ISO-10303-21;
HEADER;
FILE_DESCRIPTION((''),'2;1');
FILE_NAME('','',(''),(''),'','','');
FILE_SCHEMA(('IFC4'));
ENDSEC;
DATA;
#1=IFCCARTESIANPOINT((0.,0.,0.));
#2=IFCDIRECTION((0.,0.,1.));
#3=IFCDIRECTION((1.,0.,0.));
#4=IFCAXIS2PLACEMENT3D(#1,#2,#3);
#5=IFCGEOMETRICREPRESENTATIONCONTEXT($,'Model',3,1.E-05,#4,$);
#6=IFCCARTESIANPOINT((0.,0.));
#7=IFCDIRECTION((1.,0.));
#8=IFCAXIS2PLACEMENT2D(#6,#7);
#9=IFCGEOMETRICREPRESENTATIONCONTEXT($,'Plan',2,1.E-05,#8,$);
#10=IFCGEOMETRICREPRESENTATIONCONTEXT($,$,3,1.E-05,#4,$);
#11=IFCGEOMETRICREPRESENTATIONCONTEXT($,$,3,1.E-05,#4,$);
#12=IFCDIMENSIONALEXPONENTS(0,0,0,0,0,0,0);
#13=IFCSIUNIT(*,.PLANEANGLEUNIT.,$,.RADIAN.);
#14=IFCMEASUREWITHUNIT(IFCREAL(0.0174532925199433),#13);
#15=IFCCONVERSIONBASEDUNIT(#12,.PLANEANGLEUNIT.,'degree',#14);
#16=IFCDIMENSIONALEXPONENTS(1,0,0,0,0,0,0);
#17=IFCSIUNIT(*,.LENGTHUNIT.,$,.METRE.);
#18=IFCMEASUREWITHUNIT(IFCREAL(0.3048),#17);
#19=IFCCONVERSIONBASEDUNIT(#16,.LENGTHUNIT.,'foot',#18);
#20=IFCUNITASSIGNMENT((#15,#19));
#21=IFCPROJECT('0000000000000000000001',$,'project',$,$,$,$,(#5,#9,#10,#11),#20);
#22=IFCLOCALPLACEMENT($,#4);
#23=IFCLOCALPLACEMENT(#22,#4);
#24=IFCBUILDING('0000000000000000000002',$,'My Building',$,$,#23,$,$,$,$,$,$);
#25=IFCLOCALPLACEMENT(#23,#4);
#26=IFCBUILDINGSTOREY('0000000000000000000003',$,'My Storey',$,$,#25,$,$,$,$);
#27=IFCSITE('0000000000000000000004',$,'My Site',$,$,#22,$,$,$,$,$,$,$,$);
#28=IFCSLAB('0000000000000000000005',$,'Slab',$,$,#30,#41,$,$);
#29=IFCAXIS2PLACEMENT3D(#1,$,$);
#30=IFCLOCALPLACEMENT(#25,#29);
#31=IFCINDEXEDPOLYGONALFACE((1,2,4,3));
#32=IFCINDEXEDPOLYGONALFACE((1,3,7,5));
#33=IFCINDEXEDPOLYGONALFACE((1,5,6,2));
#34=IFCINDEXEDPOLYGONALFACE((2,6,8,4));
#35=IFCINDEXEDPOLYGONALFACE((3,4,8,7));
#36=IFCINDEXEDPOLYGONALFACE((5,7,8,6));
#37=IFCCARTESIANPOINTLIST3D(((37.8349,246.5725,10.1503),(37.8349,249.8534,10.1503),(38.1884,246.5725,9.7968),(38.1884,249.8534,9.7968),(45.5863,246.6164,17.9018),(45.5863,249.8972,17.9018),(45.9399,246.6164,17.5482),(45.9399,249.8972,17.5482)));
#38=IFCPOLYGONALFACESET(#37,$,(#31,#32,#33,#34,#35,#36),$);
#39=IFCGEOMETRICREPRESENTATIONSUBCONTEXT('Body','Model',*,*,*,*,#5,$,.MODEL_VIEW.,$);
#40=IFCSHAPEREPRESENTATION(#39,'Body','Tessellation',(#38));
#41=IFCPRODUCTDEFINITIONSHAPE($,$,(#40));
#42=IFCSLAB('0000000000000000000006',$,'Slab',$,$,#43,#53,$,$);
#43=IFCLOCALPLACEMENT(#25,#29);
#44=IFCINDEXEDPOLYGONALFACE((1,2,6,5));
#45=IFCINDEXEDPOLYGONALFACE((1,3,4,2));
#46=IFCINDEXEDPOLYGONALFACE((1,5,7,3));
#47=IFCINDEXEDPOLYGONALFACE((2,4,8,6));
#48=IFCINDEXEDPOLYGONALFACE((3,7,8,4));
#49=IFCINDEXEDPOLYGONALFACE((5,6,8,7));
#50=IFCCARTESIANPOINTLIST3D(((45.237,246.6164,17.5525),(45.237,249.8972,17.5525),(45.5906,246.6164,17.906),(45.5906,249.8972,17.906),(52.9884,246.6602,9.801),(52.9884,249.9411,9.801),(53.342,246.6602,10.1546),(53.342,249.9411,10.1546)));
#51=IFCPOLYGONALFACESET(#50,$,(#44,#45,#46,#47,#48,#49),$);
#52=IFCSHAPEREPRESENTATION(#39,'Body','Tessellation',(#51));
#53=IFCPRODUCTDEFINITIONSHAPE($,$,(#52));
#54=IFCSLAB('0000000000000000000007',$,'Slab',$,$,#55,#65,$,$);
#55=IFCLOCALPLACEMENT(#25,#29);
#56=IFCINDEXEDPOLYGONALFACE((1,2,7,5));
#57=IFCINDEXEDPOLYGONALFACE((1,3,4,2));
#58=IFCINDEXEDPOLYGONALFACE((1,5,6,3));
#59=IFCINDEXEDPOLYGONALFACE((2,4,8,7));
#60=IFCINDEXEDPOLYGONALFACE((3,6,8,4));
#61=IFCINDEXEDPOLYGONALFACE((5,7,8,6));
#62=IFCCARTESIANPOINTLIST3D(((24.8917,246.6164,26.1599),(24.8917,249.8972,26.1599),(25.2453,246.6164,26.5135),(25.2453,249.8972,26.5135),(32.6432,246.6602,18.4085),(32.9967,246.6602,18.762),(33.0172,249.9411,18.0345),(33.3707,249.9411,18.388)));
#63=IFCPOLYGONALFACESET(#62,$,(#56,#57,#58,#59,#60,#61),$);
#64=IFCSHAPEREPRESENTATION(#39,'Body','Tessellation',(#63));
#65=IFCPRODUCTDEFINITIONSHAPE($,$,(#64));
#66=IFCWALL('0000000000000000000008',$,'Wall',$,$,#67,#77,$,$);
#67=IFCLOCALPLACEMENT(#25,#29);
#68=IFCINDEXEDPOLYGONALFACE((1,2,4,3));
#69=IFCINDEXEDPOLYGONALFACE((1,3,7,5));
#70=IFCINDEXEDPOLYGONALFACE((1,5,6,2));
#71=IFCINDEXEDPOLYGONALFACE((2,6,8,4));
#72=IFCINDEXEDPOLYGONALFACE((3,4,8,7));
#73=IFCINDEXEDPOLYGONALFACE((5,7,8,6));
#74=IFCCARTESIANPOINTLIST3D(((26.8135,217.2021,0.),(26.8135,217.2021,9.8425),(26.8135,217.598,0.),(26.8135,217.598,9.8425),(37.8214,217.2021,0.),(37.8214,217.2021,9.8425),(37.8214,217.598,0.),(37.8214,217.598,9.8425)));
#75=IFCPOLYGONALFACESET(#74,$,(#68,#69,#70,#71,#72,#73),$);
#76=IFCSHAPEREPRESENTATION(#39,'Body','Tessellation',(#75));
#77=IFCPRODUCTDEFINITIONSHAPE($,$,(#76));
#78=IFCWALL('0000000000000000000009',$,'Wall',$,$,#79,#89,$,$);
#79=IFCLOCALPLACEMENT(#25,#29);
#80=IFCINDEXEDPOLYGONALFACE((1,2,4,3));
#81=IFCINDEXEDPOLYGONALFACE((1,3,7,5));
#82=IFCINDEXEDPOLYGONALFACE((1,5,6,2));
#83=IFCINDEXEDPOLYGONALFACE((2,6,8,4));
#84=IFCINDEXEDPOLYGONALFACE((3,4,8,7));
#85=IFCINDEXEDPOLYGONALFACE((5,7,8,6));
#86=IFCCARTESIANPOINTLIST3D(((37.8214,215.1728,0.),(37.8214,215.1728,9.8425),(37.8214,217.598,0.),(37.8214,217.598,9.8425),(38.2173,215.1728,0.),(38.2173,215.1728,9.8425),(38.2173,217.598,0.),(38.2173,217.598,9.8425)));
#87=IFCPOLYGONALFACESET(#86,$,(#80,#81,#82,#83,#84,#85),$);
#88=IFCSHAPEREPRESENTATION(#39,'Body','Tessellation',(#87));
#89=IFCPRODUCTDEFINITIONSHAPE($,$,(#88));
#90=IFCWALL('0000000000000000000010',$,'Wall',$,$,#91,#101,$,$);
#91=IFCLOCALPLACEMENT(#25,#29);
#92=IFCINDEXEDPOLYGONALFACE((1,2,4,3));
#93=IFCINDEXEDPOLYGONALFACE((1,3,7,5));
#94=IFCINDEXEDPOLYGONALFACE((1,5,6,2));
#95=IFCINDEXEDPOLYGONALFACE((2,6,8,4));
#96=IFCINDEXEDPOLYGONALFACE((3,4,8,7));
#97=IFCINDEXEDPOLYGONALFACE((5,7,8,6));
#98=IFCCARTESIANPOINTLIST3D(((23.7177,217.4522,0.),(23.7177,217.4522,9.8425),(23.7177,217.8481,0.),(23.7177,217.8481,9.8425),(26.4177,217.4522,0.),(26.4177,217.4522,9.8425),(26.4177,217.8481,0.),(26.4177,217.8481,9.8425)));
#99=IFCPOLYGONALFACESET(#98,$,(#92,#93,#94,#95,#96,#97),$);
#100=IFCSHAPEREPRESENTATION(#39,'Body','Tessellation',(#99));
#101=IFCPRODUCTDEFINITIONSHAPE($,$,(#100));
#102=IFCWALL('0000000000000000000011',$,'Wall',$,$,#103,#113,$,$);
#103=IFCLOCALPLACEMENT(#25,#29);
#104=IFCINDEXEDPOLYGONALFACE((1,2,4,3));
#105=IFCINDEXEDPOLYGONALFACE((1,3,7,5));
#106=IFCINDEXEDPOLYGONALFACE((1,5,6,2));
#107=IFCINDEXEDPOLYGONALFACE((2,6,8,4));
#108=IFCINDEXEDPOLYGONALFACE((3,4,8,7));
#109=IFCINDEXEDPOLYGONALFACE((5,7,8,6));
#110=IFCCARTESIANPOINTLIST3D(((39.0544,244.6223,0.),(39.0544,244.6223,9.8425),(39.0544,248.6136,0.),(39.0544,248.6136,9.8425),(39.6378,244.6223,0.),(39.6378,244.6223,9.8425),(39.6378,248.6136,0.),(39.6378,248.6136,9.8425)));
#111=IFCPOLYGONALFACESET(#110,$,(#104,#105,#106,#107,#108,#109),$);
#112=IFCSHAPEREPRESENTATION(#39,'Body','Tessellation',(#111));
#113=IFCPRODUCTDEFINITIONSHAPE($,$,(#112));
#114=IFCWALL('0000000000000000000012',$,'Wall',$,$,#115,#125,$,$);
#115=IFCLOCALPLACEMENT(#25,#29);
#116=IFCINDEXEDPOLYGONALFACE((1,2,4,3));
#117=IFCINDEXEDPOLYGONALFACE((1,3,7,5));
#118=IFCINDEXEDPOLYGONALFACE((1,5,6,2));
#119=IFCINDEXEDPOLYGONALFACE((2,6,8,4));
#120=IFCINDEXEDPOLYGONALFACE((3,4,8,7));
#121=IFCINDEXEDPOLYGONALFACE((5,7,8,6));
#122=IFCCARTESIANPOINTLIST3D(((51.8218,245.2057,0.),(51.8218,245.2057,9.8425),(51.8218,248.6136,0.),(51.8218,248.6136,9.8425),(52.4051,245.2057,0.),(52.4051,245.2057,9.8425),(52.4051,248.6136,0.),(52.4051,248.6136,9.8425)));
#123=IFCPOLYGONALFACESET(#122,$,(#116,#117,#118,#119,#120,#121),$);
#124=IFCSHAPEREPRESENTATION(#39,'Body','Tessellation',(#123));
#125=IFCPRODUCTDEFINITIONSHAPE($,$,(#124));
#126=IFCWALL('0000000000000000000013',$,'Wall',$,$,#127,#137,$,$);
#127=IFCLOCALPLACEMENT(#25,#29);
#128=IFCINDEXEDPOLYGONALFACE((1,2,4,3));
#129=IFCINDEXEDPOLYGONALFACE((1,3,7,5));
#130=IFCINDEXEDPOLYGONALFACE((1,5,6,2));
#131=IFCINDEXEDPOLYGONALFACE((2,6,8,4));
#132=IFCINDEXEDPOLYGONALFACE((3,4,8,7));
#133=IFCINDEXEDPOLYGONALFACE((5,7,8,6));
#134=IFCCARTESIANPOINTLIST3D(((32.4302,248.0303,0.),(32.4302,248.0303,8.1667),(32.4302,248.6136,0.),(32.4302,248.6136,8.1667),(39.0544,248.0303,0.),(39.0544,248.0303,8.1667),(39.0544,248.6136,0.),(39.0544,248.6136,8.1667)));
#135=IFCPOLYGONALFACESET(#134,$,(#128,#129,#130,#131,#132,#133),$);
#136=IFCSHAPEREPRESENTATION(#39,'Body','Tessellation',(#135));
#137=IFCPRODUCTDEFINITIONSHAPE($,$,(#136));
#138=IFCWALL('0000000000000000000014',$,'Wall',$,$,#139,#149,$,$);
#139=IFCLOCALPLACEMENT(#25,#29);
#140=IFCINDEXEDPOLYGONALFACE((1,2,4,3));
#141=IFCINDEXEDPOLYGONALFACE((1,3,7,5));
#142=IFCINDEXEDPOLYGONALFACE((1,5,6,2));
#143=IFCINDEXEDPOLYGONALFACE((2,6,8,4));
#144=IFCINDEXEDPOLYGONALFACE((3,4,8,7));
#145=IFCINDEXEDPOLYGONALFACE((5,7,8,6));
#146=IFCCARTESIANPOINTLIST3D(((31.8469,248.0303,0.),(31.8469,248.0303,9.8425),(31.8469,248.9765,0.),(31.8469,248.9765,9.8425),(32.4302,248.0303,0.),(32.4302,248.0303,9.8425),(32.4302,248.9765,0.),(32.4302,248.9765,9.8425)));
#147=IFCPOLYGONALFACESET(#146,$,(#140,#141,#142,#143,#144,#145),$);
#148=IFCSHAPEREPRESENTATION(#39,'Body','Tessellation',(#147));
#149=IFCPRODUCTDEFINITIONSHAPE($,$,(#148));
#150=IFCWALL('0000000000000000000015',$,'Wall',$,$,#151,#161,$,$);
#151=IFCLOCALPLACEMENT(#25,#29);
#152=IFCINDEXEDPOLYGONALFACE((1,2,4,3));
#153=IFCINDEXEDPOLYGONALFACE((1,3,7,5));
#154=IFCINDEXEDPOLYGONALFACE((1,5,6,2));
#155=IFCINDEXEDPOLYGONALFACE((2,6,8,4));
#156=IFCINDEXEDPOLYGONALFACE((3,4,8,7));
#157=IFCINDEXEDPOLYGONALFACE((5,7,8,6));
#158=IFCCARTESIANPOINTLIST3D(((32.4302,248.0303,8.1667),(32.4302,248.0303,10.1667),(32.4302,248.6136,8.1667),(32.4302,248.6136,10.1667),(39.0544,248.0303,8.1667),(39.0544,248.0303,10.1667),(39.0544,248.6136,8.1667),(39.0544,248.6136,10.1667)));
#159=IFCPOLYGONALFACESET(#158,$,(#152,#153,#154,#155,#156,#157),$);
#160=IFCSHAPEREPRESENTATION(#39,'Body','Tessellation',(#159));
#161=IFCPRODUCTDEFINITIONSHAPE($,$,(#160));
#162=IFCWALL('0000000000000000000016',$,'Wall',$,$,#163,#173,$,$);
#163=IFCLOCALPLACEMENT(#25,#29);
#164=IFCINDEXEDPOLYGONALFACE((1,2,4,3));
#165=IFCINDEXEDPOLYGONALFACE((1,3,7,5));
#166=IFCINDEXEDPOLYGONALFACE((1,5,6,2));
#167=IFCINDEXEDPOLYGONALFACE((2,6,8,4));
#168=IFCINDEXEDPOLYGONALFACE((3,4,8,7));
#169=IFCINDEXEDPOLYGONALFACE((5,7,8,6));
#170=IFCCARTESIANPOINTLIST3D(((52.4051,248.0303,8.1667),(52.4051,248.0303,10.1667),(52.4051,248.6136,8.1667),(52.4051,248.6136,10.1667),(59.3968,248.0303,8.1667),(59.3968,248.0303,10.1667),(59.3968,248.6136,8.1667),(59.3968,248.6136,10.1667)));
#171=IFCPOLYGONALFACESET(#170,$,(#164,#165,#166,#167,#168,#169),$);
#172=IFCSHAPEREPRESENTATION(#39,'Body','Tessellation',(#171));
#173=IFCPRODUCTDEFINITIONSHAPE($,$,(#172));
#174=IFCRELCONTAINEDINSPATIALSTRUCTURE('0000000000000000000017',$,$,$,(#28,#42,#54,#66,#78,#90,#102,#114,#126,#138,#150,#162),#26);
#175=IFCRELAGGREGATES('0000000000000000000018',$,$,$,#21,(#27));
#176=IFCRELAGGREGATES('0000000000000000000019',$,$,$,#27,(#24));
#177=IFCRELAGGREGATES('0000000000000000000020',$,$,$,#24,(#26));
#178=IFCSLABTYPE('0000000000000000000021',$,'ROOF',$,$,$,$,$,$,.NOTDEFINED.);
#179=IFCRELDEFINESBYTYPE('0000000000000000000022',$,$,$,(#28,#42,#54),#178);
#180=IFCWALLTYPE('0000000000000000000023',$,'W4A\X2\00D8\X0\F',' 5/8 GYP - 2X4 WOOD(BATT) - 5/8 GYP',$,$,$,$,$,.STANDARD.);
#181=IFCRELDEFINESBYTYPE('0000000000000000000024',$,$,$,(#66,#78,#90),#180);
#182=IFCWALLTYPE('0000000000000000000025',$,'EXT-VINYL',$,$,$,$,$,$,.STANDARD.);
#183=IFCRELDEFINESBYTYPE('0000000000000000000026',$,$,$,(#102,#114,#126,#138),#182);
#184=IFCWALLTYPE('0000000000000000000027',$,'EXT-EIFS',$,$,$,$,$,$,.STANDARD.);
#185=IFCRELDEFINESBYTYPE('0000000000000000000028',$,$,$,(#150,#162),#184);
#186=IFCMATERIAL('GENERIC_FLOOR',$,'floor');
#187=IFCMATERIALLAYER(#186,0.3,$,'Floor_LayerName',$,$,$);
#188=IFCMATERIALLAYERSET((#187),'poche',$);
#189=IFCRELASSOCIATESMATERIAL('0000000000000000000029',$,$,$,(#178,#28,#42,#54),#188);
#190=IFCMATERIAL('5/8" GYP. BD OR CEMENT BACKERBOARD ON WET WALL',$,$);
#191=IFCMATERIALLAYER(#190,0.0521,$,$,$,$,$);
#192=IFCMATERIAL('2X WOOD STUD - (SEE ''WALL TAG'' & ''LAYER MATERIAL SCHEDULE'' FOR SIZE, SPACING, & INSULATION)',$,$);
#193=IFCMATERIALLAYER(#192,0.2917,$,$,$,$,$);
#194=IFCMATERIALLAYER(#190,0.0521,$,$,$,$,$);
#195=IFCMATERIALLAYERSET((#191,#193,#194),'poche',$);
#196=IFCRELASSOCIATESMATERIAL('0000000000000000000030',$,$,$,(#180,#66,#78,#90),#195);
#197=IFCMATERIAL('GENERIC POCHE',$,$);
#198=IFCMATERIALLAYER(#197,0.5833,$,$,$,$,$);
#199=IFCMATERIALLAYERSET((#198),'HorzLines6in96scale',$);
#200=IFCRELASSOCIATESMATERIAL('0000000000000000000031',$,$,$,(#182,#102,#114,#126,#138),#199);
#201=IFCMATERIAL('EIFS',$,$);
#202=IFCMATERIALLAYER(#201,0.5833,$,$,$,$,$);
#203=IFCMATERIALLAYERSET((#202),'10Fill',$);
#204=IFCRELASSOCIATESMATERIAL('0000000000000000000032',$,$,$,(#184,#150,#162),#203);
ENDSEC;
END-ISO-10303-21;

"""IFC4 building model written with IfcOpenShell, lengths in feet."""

from ifc_helpers import new_model, entity, si_unit, converted_unit, frame, origin_with_axes, origin_2d_with_axis, place, context, subcontext, project, spatial, line, indexed_curve, outline, extrude, material, layer, layer_set, layer_usage, type_object, element, save


model = new_model("IFC4")

# Units and contexts
model_context = context("Model", 3, precision=1e-05, world=origin_with_axes())
plan_context = context("Plan", 2, precision=1e-05, world=origin_2d_with_axis())
context_of_model_1 = context(None, 3, precision=1e-05, world=origin_with_axes())
context_of_model_2 = context(None, 3, precision=1e-05, world=origin_with_axes())
body_context = subcontext(model_context, "Body", "Model", "MODEL_VIEW")
ifc_project = project(units=[converted_unit("PLANEANGLEUNIT", "degree", entity("IfcReal", 0.0174532925199433), si_unit("PLANEANGLEUNIT", "RADIAN"), dimensions=[0, 0, 0, 0, 0, 0, 0]), converted_unit("LENGTHUNIT", "foot", entity("IfcReal", 0.3048), si_unit("LENGTHUNIT", "METRE"), dimensions=[1, 0, 0, 0, 0, 0, 0])], contexts=[model_context, plan_context, context_of_model_1, context_of_model_2])

# Site, building, storey
site_placement = place(None, origin_with_axes())
site = spatial("IfcSite", under=ifc_project, at=site_placement, Name="My Site")
building_placement = place(site_placement, origin_with_axes())
building = spatial("IfcBuilding", under=site, at=building_placement, Name="My Building")
storey_placement = place(building_placement, origin_with_axes())
storey = spatial("IfcBuildingStorey", under=building, at=storey_placement, Name="My Storey")

# Slabs
ifc_material_1 = material(Name="GENERIC_FLOOR", Category="floor")
ifc_layer_1 = layer(ifc_material_1, 0.3, Name="Floor_LayerName")
ifc_layer_set_1 = layer_set([ifc_layer_1], Name="poche")
ifc_layer_usage_1 = layer_usage(ifc_layer_set_1, "AXIS3", "POSITIVE", 0.0)
slab_type_1 = type_object("IfcSlabType", Name="ROOF", PredefinedType="NOTDEFINED", material=ifc_layer_set_1)
slab_1_placement = place(storey_placement, frame((38.1884, 249.8534, 9.7968), z_axis=(-0.707107, 0.0, 0.707107), x_axis=(0.0, -1.0, 0.0)))
element("IfcSlab", 1, at=slab_1_placement, inside=storey, type_object=slab_type_1, material=ifc_layer_usage_1, Name="Slab", context=body_context, shape_type="SweptSolid", body=[
    extrude(outline(indexed_curve([(0.0, 0.0), (-0.0438, 10.9622), (3.237, 10.9622), (3.2808, 0.0)], segments=[line(3, 2), line(2, 1), line(1, 4), line(4, 3)], self_intersect=False)), None, (0.0, 0.0, 1.0), 0.5),
])
ifc_layer_usage_2 = layer_usage(ifc_layer_set_1, "AXIS3", "POSITIVE", 0.0)
slab_2_placement = place(storey_placement, frame((52.9884, 246.6602, 9.801), z_axis=(0.707107, 0.000001, 0.707107), x_axis=(-0.000001, 1.0, 0.0)))
element("IfcSlab", 2, at=slab_2_placement, inside=storey, type_object=slab_type_1, material=ifc_layer_usage_2, Name="Slab", context=body_context, shape_type="SweptSolid", body=[
    extrude(outline(indexed_curve([(0.0, 0.0), (-0.0438, 10.9622), (3.237, 10.9622), (3.2808, 0.0)], segments=[line(3, 2), line(2, 1), line(1, 4), line(4, 3)], self_intersect=False)), None, (0.0, 0.0, 1.0), 0.5),
])
ifc_layer_usage_3 = layer_usage(ifc_layer_set_1, "AXIS3", "POSITIVE", 0.0)
slab_3_placement = place(storey_placement, frame((32.6432, 246.6602, 18.4085), z_axis=(0.707107, 0.000001, 0.707107), x_axis=(-0.000001, 1.0, 0.0)))
element("IfcSlab", 3, at=slab_3_placement, inside=storey, type_object=slab_type_1, material=ifc_layer_usage_3, Name="Slab", context=body_context, shape_type="SweptSolid", body=[
    extrude(outline(indexed_curve([(3.237, 10.9622), (-0.0438, 10.9622), (0.0, 0.0), (3.2808, -0.5289)], segments=[line(3, 2), line(2, 1), line(1, 4), line(4, 3)], self_intersect=False)), None, (0.0, 0.0, 1.0), 0.5),
])

# Shared definitions
ifc_material_2 = material(Name="5/8\" GYP. BD OR CEMENT BACKERBOARD ON WET WALL")
ifc_layer_2 = layer(ifc_material_2, 0.0521)
ifc_material_3 = material(Name="2X WOOD STUD - (SEE 'WALL TAG' & 'LAYER MATERIAL SCHEDULE' FOR SIZE, SPACING, & INSULATION)")
ifc_layer_3 = layer(ifc_material_3, 0.2917)
ifc_layer_4 = layer(ifc_material_2, 0.0521)
ifc_layer_set_2 = layer_set([ifc_layer_2, ifc_layer_3, ifc_layer_4], Name="poche")
wall_type_1 = type_object("IfcWallType", Name="W4AØF", Description=" 5/8 GYP - 2X4 WOOD(BATT) - 5/8 GYP", PredefinedType="STANDARD", material=ifc_layer_set_2)

# Wall
ifc_layer_usage_4 = layer_usage(ifc_layer_set_2, "AXIS2", "POSITIVE", 0.0)
wall_1_placement = place(storey_placement, frame((26.8135, 217.2021, 0.0), z_axis=(0.0, 0.0, 1.0), x_axis=(1.0, 0.0, 0.0)))
element("IfcWall", 4, at=wall_1_placement, inside=storey, type_object=wall_type_1, material=ifc_layer_usage_4, Name="Wall", context=body_context, shape_type="SweptSolid", body=[
    extrude(outline(indexed_curve([(0.0, 0.0), (0.0, 0.3958), (11.0079, 0.3958), (11.0079, 0.0), (0.0, 0.0)], self_intersect=False)), origin_with_axes(), (0.0, 0.0, 1.0), 9.8425),
])

# Wall
ifc_layer_usage_5 = layer_usage(ifc_layer_set_2, "AXIS2", "POSITIVE", 0.0)
wall_2_placement = place(storey_placement, frame((37.8214, 217.598, 0.0), z_axis=(0.0, 0.0, 1.0), x_axis=(-0.000001, -1.0, 0.0)))
element("IfcWall", 5, at=wall_2_placement, inside=storey, type_object=wall_type_1, material=ifc_layer_usage_5, Name="Wall", context=body_context, shape_type="SweptSolid", body=[
    extrude(outline(indexed_curve([(0.0, 0.0), (0.0, 0.3958), (2.4252, 0.3958), (2.4252, 0.0), (0.0, 0.0)], self_intersect=False)), origin_with_axes(), (0.0, 0.0, 1.0), 9.8425),
])

# Wall
ifc_layer_usage_6 = layer_usage(ifc_layer_set_2, "AXIS2", "POSITIVE", 0.0)
wall_3_placement = place(storey_placement, frame((26.4177, 217.8481, 0.0), z_axis=(0.0, 0.0, 1.0), x_axis=(-1.0, 0.0, 0.0)))
element("IfcWall", 6, at=wall_3_placement, inside=storey, type_object=wall_type_1, material=ifc_layer_usage_6, Name="Wall", context=body_context, shape_type="SweptSolid", body=[
    extrude(outline(indexed_curve([(0.0, 0.0), (0.0, 0.3958), (2.7, 0.3958), (2.7, 0.0), (0.0, 0.0)], self_intersect=False)), origin_with_axes(), (0.0, 0.0, 1.0), 9.8425),
])

# Shared definitions
ifc_material_4 = material(Name="GENERIC POCHE")
ifc_layer_5 = layer(ifc_material_4, 0.5833)
ifc_layer_set_3 = layer_set([ifc_layer_5], Name="HorzLines6in96scale")
wall_type_2 = type_object("IfcWallType", Name="EXT-VINYL", PredefinedType="STANDARD", material=ifc_layer_set_3)

# Walls
ifc_layer_usage_7 = layer_usage(ifc_layer_set_3, "AXIS2", "POSITIVE", 0.0)
wall_4_placement = place(storey_placement, frame((39.0544, 248.6136, 0.0), z_axis=(0.0, 0.0, 1.0), x_axis=(0.0, -1.0, 0.0)))
element("IfcWall", 7, at=wall_4_placement, inside=storey, type_object=wall_type_2, material=ifc_layer_usage_7, Name="Wall", context=body_context, shape_type="SweptSolid", body=[
    extrude(outline(indexed_curve([(0.0, 0.0), (0.0, 0.5833), (3.9913, 0.5833), (3.9913, 0.0), (0.0, 0.0)], self_intersect=False)), origin_with_axes(), (0.0, 0.0, 1.0), 9.8425),
])
ifc_layer_usage_8 = layer_usage(ifc_layer_set_3, "AXIS2", "POSITIVE", 0.0)
wall_5_placement = place(storey_placement, frame((52.4051, 245.2057, 0.0), z_axis=(0.0, 0.0, 1.0), x_axis=(0.0, 1.0, 0.0)))
element("IfcWall", 8, at=wall_5_placement, inside=storey, type_object=wall_type_2, material=ifc_layer_usage_8, Name="Wall", context=body_context, shape_type="SweptSolid", body=[
    extrude(outline(indexed_curve([(0.0, 0.0), (0.0, 0.5833), (3.4079, 0.5833), (3.4079, 0.0), (0.0, 0.0)], self_intersect=False)), origin_with_axes(), (0.0, 0.0, 1.0), 9.8425),
])
ifc_layer_usage_9 = layer_usage(ifc_layer_set_3, "AXIS2", "POSITIVE", 0.0)
wall_6_placement = place(storey_placement, frame((32.4302, 248.0303, 0.0), z_axis=(0.0, 0.0, 1.0), x_axis=(1.0, 0.0, 0.0)))
element("IfcWall", 9, at=wall_6_placement, inside=storey, type_object=wall_type_2, material=ifc_layer_usage_9, Name="Wall", context=body_context, shape_type="SweptSolid", body=[
    extrude(outline(indexed_curve([(0.0, 0.0), (0.0, 0.5833), (6.6242, 0.5833), (6.6242, 0.0), (0.0, 0.0)], self_intersect=False)), origin_with_axes(), (0.0, 0.0, 1.0), 8.1667),
])
ifc_layer_usage_10 = layer_usage(ifc_layer_set_3, "AXIS2", "POSITIVE", 0.0)
wall_7_placement = place(storey_placement, frame((31.8469, 248.9765, 0.0), z_axis=(0.0, 0.0, 1.0), x_axis=(0.0, -1.0, 0.0)))
element("IfcWall", 10, at=wall_7_placement, inside=storey, type_object=wall_type_2, material=ifc_layer_usage_10, Name="Wall", context=body_context, shape_type="SweptSolid", body=[
    extrude(outline(indexed_curve([(0.0, 0.0), (0.0, 0.5833), (0.9462, 0.5833), (0.9462, 0.0), (0.0, 0.0)], self_intersect=False)), origin_with_axes(), (0.0, 0.0, 1.0), 9.8425),
])
ifc_material_5 = material(Name="EIFS")
ifc_layer_6 = layer(ifc_material_5, 0.5833)
ifc_layer_set_4 = layer_set([ifc_layer_6], Name="10Fill")
ifc_layer_usage_11 = layer_usage(ifc_layer_set_4, "AXIS2", "POSITIVE", 0.0)
wall_type_3 = type_object("IfcWallType", Name="EXT-EIFS", PredefinedType="STANDARD", material=ifc_layer_set_4)
wall_8_placement = place(storey_placement, frame((32.4302, 248.0303, 8.1667), z_axis=(0.0, 0.0, 1.0), x_axis=(1.0, 0.0, 0.0)))
element("IfcWall", 11, at=wall_8_placement, inside=storey, type_object=wall_type_3, material=ifc_layer_usage_11, Name="Wall", context=body_context, shape_type="SweptSolid", body=[
    extrude(outline(indexed_curve([(0.0, 0.0), (0.0, 0.5833), (6.6242, 0.5833), (6.6242, 0.0), (0.0, 0.0)], self_intersect=False)), origin_with_axes(), (0.0, 0.0, 1.0), 2.0),
])
ifc_layer_usage_12 = layer_usage(ifc_layer_set_4, "AXIS2", "POSITIVE", 0.0)
wall_9_placement = place(storey_placement, frame((52.4051, 248.0303, 8.1667), z_axis=(0.0, 0.0, 1.0), x_axis=(1.0, 0.0, 0.0)))
element("IfcWall", 12, at=wall_9_placement, inside=storey, type_object=wall_type_3, material=ifc_layer_usage_12, Name="Wall", context=body_context, shape_type="SweptSolid", body=[
    extrude(outline(indexed_curve([(0.0, 0.0), (0.0, 0.5833), (6.9917, 0.5833), (6.9917, 0.0), (0.0, 0.0)], self_intersect=False)), origin_with_axes(), (0.0, 0.0, 1.0), 2.0),
])

save(model, "model.ifc")
